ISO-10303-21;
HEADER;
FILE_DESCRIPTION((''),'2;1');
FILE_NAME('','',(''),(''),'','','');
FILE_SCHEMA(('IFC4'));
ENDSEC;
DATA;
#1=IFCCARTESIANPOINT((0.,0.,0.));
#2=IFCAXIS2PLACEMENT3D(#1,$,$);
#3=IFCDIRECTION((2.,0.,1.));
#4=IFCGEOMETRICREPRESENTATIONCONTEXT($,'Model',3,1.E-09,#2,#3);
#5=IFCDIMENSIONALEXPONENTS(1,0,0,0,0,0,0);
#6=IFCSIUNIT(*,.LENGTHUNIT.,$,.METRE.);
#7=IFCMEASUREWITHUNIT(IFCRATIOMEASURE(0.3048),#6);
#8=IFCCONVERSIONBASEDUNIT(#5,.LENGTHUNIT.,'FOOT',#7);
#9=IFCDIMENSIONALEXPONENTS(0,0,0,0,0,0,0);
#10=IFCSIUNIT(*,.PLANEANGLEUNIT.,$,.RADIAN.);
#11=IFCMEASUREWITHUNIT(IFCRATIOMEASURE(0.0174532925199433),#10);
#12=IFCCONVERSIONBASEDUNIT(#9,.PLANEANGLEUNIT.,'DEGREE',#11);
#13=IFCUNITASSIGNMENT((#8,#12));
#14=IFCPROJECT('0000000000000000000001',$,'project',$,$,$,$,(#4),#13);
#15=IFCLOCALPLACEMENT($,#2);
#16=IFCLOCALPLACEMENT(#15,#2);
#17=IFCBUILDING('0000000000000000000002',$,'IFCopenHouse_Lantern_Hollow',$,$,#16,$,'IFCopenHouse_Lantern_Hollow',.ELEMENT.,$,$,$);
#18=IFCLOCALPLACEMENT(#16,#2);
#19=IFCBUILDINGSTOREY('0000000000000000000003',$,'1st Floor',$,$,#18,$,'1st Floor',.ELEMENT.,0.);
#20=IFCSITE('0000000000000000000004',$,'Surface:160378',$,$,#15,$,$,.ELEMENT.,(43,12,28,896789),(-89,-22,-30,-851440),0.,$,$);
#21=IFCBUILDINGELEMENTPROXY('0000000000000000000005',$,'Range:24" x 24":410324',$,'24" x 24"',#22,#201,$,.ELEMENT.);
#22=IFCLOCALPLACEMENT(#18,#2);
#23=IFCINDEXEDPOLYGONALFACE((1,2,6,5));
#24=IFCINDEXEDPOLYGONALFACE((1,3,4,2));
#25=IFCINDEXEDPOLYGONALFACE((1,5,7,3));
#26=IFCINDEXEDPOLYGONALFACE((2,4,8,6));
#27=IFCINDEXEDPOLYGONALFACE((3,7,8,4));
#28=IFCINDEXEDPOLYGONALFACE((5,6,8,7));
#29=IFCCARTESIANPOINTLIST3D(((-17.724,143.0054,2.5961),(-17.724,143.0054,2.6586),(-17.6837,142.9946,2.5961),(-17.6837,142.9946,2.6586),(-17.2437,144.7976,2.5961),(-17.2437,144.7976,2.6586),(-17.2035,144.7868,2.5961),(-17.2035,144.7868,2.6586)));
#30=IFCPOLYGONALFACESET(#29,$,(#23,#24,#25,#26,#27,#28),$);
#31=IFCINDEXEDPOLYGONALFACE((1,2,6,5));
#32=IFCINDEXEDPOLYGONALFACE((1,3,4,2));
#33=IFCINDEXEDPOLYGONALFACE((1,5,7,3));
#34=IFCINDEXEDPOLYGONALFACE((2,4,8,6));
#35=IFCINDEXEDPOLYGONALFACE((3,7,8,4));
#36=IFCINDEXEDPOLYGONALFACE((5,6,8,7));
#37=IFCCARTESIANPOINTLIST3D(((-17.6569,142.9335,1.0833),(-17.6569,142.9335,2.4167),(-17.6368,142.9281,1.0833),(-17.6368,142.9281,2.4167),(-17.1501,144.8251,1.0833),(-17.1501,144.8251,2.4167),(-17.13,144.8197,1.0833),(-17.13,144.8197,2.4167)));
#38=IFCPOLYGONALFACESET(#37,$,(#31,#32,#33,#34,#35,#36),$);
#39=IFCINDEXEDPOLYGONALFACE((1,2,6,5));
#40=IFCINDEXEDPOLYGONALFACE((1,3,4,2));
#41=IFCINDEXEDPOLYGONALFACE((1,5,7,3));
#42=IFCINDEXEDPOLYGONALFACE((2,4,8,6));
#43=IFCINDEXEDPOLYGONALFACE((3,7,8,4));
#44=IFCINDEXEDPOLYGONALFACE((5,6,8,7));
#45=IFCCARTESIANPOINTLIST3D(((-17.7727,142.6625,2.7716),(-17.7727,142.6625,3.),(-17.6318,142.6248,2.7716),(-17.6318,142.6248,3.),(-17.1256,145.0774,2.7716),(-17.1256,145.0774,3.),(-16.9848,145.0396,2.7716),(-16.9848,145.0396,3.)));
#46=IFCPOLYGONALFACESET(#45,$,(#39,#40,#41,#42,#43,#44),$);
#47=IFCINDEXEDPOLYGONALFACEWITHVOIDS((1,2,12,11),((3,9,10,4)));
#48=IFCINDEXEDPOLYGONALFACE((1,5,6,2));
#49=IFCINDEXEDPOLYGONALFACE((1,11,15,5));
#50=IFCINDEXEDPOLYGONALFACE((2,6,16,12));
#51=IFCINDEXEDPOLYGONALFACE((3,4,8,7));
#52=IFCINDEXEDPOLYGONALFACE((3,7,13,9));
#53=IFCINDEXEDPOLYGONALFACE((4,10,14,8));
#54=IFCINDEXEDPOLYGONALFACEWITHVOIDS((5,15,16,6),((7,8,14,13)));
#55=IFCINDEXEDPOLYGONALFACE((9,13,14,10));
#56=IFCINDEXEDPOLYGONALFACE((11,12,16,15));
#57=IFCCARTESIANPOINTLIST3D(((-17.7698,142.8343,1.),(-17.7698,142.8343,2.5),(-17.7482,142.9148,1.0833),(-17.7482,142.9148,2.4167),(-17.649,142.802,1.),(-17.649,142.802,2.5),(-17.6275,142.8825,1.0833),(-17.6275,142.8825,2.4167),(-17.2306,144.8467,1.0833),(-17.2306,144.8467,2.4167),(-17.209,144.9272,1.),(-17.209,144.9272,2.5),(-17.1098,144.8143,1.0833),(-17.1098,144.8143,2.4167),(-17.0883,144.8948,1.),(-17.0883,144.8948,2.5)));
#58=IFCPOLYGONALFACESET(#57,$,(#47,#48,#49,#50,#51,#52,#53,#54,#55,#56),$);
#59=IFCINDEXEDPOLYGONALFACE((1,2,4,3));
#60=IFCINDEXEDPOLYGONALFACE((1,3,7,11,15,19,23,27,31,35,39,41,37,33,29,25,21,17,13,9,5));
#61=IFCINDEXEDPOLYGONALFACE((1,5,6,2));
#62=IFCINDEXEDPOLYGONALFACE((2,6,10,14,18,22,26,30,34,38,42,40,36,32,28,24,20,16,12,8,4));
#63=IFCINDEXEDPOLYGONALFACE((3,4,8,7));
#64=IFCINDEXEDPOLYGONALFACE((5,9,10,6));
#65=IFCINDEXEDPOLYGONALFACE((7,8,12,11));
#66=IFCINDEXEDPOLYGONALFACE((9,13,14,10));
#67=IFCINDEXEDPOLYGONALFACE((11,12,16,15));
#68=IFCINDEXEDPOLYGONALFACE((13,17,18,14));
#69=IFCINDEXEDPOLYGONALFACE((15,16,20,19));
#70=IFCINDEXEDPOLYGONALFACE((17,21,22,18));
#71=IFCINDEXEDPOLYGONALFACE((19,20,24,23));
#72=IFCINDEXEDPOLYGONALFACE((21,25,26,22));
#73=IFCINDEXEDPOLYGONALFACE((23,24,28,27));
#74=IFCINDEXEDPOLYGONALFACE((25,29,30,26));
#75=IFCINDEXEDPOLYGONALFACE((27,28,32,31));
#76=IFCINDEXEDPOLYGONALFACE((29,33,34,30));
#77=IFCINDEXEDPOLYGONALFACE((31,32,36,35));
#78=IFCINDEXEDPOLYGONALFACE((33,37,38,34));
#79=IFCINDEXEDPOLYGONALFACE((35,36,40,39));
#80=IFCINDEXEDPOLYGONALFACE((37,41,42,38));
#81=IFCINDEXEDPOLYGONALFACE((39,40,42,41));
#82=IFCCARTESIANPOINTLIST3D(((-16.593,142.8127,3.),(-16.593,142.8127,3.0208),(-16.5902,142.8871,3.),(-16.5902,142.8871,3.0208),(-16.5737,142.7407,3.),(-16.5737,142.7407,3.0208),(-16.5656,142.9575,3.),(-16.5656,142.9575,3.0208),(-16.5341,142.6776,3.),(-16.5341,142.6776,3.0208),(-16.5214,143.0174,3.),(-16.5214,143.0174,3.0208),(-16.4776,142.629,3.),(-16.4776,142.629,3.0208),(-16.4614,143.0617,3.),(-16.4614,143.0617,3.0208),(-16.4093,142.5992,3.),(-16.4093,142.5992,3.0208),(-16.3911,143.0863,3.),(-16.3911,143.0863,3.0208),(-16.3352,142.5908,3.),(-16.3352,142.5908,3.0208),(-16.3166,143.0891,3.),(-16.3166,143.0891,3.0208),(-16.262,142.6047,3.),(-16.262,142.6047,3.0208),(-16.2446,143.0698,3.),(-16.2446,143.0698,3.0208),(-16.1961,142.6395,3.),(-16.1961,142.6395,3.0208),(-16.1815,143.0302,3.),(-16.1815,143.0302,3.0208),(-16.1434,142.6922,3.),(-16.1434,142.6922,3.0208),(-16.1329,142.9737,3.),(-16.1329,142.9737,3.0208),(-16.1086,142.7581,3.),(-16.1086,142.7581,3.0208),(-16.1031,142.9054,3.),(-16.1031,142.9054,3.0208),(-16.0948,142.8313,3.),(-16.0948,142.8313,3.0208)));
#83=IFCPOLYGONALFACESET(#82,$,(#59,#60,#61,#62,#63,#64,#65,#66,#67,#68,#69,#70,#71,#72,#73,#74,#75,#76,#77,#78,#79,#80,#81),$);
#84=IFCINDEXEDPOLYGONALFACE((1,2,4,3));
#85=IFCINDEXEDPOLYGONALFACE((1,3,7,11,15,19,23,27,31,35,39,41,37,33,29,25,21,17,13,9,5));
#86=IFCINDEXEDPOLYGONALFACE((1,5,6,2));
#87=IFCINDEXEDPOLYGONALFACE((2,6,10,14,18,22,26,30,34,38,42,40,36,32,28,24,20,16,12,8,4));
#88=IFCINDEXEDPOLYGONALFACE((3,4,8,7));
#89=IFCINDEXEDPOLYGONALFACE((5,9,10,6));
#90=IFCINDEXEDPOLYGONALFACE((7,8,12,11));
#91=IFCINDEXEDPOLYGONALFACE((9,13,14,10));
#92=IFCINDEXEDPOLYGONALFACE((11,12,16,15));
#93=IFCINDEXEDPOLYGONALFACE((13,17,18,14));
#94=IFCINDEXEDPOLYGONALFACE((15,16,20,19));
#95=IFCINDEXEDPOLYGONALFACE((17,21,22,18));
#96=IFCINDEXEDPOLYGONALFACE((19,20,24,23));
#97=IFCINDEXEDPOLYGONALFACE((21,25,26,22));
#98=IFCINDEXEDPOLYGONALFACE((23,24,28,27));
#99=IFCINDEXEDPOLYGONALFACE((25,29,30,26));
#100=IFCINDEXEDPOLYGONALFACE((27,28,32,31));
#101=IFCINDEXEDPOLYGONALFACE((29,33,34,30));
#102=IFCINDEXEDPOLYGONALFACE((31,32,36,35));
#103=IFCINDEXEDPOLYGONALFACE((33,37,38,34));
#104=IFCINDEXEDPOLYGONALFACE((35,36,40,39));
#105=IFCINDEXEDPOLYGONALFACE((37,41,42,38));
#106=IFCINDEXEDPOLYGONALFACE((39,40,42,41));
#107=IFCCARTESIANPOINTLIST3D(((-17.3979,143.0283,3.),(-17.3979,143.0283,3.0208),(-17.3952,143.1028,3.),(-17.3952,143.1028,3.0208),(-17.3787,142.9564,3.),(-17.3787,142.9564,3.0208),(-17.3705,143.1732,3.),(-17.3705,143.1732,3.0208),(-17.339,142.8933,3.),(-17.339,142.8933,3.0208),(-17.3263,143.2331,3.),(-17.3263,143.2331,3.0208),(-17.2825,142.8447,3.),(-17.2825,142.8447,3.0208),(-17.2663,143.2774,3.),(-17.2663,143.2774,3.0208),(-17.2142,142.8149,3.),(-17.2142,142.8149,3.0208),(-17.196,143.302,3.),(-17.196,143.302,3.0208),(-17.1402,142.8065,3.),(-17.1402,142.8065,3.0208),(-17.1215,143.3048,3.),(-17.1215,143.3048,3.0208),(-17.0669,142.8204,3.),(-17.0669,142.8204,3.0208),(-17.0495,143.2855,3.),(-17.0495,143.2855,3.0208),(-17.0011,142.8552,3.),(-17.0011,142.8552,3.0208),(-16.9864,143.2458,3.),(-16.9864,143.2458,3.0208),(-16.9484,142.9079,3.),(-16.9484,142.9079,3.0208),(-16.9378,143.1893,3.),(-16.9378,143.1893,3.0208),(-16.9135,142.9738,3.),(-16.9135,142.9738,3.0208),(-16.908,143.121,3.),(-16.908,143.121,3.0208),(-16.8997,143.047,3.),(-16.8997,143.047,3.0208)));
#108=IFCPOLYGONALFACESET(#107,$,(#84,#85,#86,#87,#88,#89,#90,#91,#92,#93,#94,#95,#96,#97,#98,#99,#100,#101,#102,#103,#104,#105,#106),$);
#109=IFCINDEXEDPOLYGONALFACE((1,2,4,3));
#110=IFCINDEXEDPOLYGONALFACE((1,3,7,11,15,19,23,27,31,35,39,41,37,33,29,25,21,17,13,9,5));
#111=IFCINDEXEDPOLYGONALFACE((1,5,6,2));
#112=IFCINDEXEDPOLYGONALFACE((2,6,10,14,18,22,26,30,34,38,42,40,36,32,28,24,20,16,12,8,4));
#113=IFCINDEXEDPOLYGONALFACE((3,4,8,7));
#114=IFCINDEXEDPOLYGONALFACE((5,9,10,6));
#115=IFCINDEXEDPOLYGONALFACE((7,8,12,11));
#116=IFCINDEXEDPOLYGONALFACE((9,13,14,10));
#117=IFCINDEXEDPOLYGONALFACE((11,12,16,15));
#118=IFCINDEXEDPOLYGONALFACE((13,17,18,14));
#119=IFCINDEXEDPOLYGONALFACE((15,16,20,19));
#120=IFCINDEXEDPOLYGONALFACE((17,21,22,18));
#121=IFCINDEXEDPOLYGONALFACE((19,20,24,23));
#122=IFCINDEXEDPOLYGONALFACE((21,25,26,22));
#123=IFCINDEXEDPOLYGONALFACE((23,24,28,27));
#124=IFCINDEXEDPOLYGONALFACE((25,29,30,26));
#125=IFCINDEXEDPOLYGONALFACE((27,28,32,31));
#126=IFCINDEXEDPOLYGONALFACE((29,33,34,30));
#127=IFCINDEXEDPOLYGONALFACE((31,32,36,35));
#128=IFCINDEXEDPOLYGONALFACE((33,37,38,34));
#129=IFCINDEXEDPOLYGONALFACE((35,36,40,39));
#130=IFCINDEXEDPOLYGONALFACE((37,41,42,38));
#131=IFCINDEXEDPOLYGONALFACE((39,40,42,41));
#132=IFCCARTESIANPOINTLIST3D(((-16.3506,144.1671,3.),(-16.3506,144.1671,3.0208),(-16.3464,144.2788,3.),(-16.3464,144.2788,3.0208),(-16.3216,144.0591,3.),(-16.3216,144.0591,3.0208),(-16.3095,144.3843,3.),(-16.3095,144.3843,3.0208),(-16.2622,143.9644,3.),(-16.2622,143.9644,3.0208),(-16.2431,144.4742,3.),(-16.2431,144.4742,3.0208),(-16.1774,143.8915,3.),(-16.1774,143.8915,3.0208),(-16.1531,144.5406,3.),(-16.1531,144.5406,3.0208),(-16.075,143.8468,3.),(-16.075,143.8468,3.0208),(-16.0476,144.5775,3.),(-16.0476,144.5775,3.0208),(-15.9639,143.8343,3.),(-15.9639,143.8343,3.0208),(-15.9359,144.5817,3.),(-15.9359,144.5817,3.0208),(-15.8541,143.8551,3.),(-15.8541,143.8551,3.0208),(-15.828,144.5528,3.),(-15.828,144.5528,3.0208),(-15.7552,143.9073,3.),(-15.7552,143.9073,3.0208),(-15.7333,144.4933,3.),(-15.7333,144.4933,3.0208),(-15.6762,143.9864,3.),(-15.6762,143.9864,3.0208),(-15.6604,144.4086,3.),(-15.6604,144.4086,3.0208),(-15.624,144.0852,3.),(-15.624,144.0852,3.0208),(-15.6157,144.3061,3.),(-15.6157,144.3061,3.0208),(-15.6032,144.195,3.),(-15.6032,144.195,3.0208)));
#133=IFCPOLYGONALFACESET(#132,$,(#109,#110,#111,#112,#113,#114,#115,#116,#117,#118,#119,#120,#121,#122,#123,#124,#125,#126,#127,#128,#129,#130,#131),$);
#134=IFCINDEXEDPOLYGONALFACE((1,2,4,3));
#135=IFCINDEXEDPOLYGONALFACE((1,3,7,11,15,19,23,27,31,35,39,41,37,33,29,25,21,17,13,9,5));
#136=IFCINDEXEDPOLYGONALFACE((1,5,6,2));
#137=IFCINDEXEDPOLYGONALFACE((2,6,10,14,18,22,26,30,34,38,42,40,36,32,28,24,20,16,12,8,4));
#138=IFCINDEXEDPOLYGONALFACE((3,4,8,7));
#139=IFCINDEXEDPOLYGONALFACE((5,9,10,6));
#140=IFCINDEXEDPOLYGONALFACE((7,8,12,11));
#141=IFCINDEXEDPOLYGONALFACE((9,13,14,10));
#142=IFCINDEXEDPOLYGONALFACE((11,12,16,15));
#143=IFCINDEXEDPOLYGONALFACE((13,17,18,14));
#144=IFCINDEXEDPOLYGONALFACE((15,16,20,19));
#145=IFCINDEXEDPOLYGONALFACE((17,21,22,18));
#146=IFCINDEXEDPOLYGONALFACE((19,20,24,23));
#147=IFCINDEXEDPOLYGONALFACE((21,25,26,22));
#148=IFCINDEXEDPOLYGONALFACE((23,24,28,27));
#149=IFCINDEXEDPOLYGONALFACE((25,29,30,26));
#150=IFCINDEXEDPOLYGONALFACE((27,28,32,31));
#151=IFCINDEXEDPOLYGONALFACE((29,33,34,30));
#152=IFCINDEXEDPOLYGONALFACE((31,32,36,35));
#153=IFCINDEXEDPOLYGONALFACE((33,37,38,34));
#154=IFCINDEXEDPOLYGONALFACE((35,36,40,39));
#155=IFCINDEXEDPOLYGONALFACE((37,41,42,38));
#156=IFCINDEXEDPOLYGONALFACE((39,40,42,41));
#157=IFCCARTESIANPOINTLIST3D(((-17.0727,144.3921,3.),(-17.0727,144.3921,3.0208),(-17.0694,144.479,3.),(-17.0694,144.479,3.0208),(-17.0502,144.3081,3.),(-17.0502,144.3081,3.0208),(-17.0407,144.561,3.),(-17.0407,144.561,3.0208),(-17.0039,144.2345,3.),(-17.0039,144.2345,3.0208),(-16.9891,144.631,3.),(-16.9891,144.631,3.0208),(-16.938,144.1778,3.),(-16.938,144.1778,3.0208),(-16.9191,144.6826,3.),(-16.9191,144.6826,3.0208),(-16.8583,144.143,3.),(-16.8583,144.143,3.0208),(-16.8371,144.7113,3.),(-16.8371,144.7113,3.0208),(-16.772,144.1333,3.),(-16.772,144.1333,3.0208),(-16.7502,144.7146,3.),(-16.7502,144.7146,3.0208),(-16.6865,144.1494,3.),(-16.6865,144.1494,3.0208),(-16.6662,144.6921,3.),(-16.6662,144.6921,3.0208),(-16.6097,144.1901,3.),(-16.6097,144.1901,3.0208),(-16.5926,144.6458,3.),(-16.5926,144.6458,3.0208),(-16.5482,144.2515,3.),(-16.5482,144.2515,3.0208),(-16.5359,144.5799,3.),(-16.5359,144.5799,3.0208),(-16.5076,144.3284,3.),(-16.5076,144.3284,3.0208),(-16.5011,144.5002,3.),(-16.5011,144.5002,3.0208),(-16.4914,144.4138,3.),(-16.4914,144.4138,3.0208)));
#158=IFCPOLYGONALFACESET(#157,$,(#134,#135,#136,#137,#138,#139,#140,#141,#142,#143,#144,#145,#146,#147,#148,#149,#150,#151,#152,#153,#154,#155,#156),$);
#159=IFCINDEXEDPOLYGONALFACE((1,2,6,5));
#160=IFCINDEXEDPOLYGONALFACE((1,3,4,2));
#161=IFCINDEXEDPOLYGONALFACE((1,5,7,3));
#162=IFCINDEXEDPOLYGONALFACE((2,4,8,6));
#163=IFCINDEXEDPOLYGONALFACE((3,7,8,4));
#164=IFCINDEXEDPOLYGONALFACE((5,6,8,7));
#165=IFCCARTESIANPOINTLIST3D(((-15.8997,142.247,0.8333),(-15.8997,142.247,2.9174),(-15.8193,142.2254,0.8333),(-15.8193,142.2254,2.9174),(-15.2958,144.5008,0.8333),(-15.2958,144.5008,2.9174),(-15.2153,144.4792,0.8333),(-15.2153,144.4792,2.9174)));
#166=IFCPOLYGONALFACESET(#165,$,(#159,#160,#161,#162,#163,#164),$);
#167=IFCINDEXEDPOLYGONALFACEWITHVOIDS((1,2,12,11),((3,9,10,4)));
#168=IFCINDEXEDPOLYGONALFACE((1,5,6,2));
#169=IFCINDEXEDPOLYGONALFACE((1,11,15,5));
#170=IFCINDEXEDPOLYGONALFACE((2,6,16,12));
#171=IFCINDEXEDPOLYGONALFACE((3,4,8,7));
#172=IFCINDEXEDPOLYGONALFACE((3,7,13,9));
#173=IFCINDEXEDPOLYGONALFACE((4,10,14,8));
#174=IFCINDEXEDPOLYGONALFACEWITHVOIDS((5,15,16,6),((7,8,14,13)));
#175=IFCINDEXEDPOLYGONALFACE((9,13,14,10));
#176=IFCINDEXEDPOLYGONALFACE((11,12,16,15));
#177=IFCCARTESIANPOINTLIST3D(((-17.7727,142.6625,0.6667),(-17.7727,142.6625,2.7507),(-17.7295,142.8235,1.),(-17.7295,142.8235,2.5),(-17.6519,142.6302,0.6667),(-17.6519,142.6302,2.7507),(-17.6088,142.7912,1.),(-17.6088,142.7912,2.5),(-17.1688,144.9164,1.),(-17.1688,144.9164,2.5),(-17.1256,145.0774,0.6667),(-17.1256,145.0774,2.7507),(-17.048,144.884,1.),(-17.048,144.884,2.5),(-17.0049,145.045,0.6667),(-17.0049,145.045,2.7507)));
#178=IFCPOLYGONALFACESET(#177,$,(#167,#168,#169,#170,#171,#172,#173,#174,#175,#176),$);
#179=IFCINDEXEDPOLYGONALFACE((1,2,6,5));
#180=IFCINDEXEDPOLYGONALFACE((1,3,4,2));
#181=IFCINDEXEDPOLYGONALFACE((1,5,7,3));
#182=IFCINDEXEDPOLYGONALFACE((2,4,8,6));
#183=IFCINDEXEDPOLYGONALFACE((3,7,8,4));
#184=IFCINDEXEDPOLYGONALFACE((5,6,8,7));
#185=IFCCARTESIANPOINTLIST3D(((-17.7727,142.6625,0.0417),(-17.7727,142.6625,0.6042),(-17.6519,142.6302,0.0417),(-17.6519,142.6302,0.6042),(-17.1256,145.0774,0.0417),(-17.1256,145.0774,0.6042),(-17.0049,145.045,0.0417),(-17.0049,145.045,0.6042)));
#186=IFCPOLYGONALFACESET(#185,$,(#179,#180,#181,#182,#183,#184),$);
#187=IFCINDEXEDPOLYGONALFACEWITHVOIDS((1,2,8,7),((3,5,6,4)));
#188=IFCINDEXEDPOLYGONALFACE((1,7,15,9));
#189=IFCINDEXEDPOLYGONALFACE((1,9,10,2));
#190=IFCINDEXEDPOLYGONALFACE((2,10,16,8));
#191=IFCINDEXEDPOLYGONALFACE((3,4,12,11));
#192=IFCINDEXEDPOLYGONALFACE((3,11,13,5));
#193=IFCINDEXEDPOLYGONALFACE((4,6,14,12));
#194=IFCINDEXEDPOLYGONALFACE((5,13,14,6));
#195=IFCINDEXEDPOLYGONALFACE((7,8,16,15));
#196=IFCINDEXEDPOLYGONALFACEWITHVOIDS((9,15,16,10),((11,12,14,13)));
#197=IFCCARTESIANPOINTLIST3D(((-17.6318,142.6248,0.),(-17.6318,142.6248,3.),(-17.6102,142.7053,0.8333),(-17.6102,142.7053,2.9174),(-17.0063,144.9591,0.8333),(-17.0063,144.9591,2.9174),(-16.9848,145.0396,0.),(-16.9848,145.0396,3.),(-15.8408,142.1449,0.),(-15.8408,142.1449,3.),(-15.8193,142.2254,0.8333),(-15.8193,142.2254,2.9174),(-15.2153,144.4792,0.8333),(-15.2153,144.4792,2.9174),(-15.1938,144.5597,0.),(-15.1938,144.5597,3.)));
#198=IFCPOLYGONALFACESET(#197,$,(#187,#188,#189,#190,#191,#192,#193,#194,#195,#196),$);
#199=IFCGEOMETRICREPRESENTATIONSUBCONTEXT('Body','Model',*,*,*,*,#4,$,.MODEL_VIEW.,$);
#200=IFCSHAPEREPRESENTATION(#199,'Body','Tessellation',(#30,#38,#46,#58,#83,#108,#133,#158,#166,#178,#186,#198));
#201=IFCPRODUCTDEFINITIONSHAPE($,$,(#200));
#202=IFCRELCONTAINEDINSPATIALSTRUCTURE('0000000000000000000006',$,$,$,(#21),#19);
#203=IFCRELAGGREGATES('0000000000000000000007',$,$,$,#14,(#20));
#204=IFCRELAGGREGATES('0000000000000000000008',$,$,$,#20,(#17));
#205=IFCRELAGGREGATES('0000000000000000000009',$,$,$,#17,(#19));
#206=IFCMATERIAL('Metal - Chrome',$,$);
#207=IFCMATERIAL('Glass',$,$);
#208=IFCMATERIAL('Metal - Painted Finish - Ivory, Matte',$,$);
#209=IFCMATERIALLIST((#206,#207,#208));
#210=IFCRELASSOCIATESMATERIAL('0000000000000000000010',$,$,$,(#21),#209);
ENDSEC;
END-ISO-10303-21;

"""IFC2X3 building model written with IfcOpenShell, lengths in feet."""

from ifc_helpers import new_model, entity, si_unit, converted_unit, direction, frame, frame_2d, origin, origin_2d_with_axis, place, context, subcontext, project, spatial, polyline, rectangle, circle, outline, extrude, source, transform, mapped, material, material_list, element, save


model = new_model("IFC2X3")

# Units and contexts
model_context = context("Model", 3, precision=1e-09, world=origin(), true_north=direction((2.0, 0.0, 1.0)))
body_context = subcontext(model_context, "Body", "Model", "MODEL_VIEW")
ifc_project = project(units=[converted_unit("LENGTHUNIT", "FOOT", entity("IfcRatioMeasure", 0.3048), si_unit("LENGTHUNIT", "METRE"), dimensions=[1, 0, 0, 0, 0, 0, 0]), converted_unit("PLANEANGLEUNIT", "DEGREE", entity("IfcRatioMeasure", 0.0174532925199433), si_unit("PLANEANGLEUNIT", "RADIAN"), dimensions=[0, 0, 0, 0, 0, 0, 0])], contexts=[model_context])

# Site, building, storey
site_placement = place(None, origin())
site = spatial("IfcSite", under=ifc_project, at=site_placement, Name="Surface:160378", CompositionType="ELEMENT", RefLatitude=(43, 12, 28, 896789), RefLongitude=(-89, -22, -30, -851440), RefElevation=0.0)
building_placement = place(site_placement, origin())
building = spatial("IfcBuilding", under=site, at=building_placement, Name="IFCopenHouse_Lantern_Hollow", LongName="IFCopenHouse_Lantern_Hollow", CompositionType="ELEMENT")
storey_placement = place(building_placement, origin())
storey = spatial("IfcBuildingStorey", under=building, at=storey_placement, Name="1st Floor", LongName="1st Floor", CompositionType="ELEMENT", Elevation=0.0)

# Building element proxy
ifc_material_1 = material(Name="Metal - Chrome")
ifc_material_2 = material(Name="Glass")
ifc_material_3 = material(Name="Metal - Painted Finish - Ivory, Matte")
ifc_material_list_1 = material_list([ifc_material_1, ifc_material_2, ifc_material_3])
shared_shape_1 = source(origin(), body_context, "Body", "SweptSolid", [
    extrude(rectangle(XDim=0.0417, YDim=1.8554, at=origin_2d_with_axis()), frame((1.2285, -0.0208, 2.5961), z_axis=(0.0, 0.0, 1.0), x_axis=(0.0, 1.0, 0.0)), (0.0, 0.0, 1.0), 0.0625),
    extrude(rectangle(XDim=0.0208, YDim=1.9583, at=frame_2d((0.0, 0.0), x_axis=(1.0, 0.0))), frame((1.2292, 0.0521, 1.0833), z_axis=(0.0, 0.0, 1.0), x_axis=(0.0, 1.0, 0.0)), (0.0, 0.0, 1.0), 1.3333),
    extrude(rectangle(XDim=0.1458, YDim=2.5, at=origin_2d_with_axis()), frame((1.25, 0.0729, 2.7716), z_axis=(0.0, 0.0, 1.0), x_axis=(0.0, 1.0, 0.0)), (0.0, 0.0, 1.0), 0.2284),
    extrude(outline(polyline([(-0.75, -1.0833), (0.75, -1.0833), (0.75, 1.0833), (-0.75, 1.0833), (-0.75, -1.0833)]), holes=[polyline([(-0.6667, -1.0), (-0.6667, 1.0), (0.6667, 1.0), (0.6667, -1.0), (-0.6667, -1.0)])]), frame((1.25, -0.0417, 1.75), z_axis=(0.0, 1.0, 0.0), x_axis=(0.0, 0.0, -1.0)), (0.0, 0.0, 1.0), 0.125),
    extrude(circle(Radius=0.25, at=frame_2d((0.0, 0.0), x_axis=(1.0, 0.0))), frame((1.9583, 1.3333, 3.0)), (0.0, 0.0, 1.0), 0.0208),
    extrude(circle(Radius=0.25, at=frame_2d((0.0, 0.0), x_axis=(1.0, 0.0))), frame((1.9583, 0.5, 3.0)), (0.0, 0.0, 1.0), 0.0208),
    extrude(circle(Radius=0.375, at=frame_2d((0.0, 0.0), x_axis=(1.0, 0.0))), frame((0.5417, 1.3333, 3.0)), (0.0, 0.0, 1.0), 0.0208),
    extrude(circle(Radius=0.2917, at=frame_2d((0.0, 0.0), x_axis=(1.0, 0.0))), frame((0.5417, 0.5, 3.0)), (0.0, 0.0, 1.0), 0.0208),
    extrude(rectangle(XDim=0.0833, YDim=2.3333, at=origin_2d_with_axis()), frame((1.25, 1.9583, 0.8333), z_axis=(0.0, 0.0, 1.0), x_axis=(0.0, -1.0, 0.0)), (0.0, 0.0, 1.0), 2.0841),
    extrude(outline(polyline([(-1.042, -1.25), (1.042, -1.25), (1.042, 1.25), (-1.042, 1.25), (-1.042, -1.25)]), holes=[polyline([(-0.7913, -1.0833), (-0.7913, 1.0833), (0.7087, 1.0833), (0.7087, -1.0833), (-0.7913, -1.0833)])]), frame((1.25, 0.0, 1.7087), z_axis=(0.0, 1.0, 0.0), x_axis=(0.0, 0.0, -1.0)), (0.0, 0.0, 1.0), 0.125),
    extrude(rectangle(XDim=0.125, YDim=2.5, at=origin_2d_with_axis()), frame((1.25, 0.0625, 0.0417), z_axis=(0.0, 0.0, 1.0), x_axis=(0.0, 1.0, 0.0)), (0.0, 0.0, 1.0), 0.5625),
    extrude(outline(polyline([(-1.5, -1.25), (1.5, -1.25), (1.5, 1.25), (-1.5, 1.25), (-1.5, -1.25)]), holes=[polyline([(-1.4174, -1.1667), (-1.4174, 1.1667), (0.6667, 1.1667), (0.6667, -1.1667), (-1.4174, -1.1667)])]), frame((1.25, 0.1458, 1.5), z_axis=(0.0, 1.0, 0.0), x_axis=(0.0, 0.0, -1.0)), (0.0, 0.0, 1.0), 1.8542),
])
proxy_1_placement = place(storey_placement, frame((-17.1256, 145.0774, 0.0), z_axis=(0.0, 0.0, 1.0), x_axis=(-0.258819, -0.965926, 0.0)))
element("IfcBuildingElementProxy", 1, at=proxy_1_placement, inside=storey, material=ifc_material_list_1, Name="Range:24\" x 24\":410324", ObjectType="24\" x 24\"", CompositionType="ELEMENT", context=body_context, shape_type="MappedRepresentation", body=[
    mapped(shared_shape_1, transform((0.0, 0.0, 0.0), scale=1.0)),
])

save(model, "model.ifc")
